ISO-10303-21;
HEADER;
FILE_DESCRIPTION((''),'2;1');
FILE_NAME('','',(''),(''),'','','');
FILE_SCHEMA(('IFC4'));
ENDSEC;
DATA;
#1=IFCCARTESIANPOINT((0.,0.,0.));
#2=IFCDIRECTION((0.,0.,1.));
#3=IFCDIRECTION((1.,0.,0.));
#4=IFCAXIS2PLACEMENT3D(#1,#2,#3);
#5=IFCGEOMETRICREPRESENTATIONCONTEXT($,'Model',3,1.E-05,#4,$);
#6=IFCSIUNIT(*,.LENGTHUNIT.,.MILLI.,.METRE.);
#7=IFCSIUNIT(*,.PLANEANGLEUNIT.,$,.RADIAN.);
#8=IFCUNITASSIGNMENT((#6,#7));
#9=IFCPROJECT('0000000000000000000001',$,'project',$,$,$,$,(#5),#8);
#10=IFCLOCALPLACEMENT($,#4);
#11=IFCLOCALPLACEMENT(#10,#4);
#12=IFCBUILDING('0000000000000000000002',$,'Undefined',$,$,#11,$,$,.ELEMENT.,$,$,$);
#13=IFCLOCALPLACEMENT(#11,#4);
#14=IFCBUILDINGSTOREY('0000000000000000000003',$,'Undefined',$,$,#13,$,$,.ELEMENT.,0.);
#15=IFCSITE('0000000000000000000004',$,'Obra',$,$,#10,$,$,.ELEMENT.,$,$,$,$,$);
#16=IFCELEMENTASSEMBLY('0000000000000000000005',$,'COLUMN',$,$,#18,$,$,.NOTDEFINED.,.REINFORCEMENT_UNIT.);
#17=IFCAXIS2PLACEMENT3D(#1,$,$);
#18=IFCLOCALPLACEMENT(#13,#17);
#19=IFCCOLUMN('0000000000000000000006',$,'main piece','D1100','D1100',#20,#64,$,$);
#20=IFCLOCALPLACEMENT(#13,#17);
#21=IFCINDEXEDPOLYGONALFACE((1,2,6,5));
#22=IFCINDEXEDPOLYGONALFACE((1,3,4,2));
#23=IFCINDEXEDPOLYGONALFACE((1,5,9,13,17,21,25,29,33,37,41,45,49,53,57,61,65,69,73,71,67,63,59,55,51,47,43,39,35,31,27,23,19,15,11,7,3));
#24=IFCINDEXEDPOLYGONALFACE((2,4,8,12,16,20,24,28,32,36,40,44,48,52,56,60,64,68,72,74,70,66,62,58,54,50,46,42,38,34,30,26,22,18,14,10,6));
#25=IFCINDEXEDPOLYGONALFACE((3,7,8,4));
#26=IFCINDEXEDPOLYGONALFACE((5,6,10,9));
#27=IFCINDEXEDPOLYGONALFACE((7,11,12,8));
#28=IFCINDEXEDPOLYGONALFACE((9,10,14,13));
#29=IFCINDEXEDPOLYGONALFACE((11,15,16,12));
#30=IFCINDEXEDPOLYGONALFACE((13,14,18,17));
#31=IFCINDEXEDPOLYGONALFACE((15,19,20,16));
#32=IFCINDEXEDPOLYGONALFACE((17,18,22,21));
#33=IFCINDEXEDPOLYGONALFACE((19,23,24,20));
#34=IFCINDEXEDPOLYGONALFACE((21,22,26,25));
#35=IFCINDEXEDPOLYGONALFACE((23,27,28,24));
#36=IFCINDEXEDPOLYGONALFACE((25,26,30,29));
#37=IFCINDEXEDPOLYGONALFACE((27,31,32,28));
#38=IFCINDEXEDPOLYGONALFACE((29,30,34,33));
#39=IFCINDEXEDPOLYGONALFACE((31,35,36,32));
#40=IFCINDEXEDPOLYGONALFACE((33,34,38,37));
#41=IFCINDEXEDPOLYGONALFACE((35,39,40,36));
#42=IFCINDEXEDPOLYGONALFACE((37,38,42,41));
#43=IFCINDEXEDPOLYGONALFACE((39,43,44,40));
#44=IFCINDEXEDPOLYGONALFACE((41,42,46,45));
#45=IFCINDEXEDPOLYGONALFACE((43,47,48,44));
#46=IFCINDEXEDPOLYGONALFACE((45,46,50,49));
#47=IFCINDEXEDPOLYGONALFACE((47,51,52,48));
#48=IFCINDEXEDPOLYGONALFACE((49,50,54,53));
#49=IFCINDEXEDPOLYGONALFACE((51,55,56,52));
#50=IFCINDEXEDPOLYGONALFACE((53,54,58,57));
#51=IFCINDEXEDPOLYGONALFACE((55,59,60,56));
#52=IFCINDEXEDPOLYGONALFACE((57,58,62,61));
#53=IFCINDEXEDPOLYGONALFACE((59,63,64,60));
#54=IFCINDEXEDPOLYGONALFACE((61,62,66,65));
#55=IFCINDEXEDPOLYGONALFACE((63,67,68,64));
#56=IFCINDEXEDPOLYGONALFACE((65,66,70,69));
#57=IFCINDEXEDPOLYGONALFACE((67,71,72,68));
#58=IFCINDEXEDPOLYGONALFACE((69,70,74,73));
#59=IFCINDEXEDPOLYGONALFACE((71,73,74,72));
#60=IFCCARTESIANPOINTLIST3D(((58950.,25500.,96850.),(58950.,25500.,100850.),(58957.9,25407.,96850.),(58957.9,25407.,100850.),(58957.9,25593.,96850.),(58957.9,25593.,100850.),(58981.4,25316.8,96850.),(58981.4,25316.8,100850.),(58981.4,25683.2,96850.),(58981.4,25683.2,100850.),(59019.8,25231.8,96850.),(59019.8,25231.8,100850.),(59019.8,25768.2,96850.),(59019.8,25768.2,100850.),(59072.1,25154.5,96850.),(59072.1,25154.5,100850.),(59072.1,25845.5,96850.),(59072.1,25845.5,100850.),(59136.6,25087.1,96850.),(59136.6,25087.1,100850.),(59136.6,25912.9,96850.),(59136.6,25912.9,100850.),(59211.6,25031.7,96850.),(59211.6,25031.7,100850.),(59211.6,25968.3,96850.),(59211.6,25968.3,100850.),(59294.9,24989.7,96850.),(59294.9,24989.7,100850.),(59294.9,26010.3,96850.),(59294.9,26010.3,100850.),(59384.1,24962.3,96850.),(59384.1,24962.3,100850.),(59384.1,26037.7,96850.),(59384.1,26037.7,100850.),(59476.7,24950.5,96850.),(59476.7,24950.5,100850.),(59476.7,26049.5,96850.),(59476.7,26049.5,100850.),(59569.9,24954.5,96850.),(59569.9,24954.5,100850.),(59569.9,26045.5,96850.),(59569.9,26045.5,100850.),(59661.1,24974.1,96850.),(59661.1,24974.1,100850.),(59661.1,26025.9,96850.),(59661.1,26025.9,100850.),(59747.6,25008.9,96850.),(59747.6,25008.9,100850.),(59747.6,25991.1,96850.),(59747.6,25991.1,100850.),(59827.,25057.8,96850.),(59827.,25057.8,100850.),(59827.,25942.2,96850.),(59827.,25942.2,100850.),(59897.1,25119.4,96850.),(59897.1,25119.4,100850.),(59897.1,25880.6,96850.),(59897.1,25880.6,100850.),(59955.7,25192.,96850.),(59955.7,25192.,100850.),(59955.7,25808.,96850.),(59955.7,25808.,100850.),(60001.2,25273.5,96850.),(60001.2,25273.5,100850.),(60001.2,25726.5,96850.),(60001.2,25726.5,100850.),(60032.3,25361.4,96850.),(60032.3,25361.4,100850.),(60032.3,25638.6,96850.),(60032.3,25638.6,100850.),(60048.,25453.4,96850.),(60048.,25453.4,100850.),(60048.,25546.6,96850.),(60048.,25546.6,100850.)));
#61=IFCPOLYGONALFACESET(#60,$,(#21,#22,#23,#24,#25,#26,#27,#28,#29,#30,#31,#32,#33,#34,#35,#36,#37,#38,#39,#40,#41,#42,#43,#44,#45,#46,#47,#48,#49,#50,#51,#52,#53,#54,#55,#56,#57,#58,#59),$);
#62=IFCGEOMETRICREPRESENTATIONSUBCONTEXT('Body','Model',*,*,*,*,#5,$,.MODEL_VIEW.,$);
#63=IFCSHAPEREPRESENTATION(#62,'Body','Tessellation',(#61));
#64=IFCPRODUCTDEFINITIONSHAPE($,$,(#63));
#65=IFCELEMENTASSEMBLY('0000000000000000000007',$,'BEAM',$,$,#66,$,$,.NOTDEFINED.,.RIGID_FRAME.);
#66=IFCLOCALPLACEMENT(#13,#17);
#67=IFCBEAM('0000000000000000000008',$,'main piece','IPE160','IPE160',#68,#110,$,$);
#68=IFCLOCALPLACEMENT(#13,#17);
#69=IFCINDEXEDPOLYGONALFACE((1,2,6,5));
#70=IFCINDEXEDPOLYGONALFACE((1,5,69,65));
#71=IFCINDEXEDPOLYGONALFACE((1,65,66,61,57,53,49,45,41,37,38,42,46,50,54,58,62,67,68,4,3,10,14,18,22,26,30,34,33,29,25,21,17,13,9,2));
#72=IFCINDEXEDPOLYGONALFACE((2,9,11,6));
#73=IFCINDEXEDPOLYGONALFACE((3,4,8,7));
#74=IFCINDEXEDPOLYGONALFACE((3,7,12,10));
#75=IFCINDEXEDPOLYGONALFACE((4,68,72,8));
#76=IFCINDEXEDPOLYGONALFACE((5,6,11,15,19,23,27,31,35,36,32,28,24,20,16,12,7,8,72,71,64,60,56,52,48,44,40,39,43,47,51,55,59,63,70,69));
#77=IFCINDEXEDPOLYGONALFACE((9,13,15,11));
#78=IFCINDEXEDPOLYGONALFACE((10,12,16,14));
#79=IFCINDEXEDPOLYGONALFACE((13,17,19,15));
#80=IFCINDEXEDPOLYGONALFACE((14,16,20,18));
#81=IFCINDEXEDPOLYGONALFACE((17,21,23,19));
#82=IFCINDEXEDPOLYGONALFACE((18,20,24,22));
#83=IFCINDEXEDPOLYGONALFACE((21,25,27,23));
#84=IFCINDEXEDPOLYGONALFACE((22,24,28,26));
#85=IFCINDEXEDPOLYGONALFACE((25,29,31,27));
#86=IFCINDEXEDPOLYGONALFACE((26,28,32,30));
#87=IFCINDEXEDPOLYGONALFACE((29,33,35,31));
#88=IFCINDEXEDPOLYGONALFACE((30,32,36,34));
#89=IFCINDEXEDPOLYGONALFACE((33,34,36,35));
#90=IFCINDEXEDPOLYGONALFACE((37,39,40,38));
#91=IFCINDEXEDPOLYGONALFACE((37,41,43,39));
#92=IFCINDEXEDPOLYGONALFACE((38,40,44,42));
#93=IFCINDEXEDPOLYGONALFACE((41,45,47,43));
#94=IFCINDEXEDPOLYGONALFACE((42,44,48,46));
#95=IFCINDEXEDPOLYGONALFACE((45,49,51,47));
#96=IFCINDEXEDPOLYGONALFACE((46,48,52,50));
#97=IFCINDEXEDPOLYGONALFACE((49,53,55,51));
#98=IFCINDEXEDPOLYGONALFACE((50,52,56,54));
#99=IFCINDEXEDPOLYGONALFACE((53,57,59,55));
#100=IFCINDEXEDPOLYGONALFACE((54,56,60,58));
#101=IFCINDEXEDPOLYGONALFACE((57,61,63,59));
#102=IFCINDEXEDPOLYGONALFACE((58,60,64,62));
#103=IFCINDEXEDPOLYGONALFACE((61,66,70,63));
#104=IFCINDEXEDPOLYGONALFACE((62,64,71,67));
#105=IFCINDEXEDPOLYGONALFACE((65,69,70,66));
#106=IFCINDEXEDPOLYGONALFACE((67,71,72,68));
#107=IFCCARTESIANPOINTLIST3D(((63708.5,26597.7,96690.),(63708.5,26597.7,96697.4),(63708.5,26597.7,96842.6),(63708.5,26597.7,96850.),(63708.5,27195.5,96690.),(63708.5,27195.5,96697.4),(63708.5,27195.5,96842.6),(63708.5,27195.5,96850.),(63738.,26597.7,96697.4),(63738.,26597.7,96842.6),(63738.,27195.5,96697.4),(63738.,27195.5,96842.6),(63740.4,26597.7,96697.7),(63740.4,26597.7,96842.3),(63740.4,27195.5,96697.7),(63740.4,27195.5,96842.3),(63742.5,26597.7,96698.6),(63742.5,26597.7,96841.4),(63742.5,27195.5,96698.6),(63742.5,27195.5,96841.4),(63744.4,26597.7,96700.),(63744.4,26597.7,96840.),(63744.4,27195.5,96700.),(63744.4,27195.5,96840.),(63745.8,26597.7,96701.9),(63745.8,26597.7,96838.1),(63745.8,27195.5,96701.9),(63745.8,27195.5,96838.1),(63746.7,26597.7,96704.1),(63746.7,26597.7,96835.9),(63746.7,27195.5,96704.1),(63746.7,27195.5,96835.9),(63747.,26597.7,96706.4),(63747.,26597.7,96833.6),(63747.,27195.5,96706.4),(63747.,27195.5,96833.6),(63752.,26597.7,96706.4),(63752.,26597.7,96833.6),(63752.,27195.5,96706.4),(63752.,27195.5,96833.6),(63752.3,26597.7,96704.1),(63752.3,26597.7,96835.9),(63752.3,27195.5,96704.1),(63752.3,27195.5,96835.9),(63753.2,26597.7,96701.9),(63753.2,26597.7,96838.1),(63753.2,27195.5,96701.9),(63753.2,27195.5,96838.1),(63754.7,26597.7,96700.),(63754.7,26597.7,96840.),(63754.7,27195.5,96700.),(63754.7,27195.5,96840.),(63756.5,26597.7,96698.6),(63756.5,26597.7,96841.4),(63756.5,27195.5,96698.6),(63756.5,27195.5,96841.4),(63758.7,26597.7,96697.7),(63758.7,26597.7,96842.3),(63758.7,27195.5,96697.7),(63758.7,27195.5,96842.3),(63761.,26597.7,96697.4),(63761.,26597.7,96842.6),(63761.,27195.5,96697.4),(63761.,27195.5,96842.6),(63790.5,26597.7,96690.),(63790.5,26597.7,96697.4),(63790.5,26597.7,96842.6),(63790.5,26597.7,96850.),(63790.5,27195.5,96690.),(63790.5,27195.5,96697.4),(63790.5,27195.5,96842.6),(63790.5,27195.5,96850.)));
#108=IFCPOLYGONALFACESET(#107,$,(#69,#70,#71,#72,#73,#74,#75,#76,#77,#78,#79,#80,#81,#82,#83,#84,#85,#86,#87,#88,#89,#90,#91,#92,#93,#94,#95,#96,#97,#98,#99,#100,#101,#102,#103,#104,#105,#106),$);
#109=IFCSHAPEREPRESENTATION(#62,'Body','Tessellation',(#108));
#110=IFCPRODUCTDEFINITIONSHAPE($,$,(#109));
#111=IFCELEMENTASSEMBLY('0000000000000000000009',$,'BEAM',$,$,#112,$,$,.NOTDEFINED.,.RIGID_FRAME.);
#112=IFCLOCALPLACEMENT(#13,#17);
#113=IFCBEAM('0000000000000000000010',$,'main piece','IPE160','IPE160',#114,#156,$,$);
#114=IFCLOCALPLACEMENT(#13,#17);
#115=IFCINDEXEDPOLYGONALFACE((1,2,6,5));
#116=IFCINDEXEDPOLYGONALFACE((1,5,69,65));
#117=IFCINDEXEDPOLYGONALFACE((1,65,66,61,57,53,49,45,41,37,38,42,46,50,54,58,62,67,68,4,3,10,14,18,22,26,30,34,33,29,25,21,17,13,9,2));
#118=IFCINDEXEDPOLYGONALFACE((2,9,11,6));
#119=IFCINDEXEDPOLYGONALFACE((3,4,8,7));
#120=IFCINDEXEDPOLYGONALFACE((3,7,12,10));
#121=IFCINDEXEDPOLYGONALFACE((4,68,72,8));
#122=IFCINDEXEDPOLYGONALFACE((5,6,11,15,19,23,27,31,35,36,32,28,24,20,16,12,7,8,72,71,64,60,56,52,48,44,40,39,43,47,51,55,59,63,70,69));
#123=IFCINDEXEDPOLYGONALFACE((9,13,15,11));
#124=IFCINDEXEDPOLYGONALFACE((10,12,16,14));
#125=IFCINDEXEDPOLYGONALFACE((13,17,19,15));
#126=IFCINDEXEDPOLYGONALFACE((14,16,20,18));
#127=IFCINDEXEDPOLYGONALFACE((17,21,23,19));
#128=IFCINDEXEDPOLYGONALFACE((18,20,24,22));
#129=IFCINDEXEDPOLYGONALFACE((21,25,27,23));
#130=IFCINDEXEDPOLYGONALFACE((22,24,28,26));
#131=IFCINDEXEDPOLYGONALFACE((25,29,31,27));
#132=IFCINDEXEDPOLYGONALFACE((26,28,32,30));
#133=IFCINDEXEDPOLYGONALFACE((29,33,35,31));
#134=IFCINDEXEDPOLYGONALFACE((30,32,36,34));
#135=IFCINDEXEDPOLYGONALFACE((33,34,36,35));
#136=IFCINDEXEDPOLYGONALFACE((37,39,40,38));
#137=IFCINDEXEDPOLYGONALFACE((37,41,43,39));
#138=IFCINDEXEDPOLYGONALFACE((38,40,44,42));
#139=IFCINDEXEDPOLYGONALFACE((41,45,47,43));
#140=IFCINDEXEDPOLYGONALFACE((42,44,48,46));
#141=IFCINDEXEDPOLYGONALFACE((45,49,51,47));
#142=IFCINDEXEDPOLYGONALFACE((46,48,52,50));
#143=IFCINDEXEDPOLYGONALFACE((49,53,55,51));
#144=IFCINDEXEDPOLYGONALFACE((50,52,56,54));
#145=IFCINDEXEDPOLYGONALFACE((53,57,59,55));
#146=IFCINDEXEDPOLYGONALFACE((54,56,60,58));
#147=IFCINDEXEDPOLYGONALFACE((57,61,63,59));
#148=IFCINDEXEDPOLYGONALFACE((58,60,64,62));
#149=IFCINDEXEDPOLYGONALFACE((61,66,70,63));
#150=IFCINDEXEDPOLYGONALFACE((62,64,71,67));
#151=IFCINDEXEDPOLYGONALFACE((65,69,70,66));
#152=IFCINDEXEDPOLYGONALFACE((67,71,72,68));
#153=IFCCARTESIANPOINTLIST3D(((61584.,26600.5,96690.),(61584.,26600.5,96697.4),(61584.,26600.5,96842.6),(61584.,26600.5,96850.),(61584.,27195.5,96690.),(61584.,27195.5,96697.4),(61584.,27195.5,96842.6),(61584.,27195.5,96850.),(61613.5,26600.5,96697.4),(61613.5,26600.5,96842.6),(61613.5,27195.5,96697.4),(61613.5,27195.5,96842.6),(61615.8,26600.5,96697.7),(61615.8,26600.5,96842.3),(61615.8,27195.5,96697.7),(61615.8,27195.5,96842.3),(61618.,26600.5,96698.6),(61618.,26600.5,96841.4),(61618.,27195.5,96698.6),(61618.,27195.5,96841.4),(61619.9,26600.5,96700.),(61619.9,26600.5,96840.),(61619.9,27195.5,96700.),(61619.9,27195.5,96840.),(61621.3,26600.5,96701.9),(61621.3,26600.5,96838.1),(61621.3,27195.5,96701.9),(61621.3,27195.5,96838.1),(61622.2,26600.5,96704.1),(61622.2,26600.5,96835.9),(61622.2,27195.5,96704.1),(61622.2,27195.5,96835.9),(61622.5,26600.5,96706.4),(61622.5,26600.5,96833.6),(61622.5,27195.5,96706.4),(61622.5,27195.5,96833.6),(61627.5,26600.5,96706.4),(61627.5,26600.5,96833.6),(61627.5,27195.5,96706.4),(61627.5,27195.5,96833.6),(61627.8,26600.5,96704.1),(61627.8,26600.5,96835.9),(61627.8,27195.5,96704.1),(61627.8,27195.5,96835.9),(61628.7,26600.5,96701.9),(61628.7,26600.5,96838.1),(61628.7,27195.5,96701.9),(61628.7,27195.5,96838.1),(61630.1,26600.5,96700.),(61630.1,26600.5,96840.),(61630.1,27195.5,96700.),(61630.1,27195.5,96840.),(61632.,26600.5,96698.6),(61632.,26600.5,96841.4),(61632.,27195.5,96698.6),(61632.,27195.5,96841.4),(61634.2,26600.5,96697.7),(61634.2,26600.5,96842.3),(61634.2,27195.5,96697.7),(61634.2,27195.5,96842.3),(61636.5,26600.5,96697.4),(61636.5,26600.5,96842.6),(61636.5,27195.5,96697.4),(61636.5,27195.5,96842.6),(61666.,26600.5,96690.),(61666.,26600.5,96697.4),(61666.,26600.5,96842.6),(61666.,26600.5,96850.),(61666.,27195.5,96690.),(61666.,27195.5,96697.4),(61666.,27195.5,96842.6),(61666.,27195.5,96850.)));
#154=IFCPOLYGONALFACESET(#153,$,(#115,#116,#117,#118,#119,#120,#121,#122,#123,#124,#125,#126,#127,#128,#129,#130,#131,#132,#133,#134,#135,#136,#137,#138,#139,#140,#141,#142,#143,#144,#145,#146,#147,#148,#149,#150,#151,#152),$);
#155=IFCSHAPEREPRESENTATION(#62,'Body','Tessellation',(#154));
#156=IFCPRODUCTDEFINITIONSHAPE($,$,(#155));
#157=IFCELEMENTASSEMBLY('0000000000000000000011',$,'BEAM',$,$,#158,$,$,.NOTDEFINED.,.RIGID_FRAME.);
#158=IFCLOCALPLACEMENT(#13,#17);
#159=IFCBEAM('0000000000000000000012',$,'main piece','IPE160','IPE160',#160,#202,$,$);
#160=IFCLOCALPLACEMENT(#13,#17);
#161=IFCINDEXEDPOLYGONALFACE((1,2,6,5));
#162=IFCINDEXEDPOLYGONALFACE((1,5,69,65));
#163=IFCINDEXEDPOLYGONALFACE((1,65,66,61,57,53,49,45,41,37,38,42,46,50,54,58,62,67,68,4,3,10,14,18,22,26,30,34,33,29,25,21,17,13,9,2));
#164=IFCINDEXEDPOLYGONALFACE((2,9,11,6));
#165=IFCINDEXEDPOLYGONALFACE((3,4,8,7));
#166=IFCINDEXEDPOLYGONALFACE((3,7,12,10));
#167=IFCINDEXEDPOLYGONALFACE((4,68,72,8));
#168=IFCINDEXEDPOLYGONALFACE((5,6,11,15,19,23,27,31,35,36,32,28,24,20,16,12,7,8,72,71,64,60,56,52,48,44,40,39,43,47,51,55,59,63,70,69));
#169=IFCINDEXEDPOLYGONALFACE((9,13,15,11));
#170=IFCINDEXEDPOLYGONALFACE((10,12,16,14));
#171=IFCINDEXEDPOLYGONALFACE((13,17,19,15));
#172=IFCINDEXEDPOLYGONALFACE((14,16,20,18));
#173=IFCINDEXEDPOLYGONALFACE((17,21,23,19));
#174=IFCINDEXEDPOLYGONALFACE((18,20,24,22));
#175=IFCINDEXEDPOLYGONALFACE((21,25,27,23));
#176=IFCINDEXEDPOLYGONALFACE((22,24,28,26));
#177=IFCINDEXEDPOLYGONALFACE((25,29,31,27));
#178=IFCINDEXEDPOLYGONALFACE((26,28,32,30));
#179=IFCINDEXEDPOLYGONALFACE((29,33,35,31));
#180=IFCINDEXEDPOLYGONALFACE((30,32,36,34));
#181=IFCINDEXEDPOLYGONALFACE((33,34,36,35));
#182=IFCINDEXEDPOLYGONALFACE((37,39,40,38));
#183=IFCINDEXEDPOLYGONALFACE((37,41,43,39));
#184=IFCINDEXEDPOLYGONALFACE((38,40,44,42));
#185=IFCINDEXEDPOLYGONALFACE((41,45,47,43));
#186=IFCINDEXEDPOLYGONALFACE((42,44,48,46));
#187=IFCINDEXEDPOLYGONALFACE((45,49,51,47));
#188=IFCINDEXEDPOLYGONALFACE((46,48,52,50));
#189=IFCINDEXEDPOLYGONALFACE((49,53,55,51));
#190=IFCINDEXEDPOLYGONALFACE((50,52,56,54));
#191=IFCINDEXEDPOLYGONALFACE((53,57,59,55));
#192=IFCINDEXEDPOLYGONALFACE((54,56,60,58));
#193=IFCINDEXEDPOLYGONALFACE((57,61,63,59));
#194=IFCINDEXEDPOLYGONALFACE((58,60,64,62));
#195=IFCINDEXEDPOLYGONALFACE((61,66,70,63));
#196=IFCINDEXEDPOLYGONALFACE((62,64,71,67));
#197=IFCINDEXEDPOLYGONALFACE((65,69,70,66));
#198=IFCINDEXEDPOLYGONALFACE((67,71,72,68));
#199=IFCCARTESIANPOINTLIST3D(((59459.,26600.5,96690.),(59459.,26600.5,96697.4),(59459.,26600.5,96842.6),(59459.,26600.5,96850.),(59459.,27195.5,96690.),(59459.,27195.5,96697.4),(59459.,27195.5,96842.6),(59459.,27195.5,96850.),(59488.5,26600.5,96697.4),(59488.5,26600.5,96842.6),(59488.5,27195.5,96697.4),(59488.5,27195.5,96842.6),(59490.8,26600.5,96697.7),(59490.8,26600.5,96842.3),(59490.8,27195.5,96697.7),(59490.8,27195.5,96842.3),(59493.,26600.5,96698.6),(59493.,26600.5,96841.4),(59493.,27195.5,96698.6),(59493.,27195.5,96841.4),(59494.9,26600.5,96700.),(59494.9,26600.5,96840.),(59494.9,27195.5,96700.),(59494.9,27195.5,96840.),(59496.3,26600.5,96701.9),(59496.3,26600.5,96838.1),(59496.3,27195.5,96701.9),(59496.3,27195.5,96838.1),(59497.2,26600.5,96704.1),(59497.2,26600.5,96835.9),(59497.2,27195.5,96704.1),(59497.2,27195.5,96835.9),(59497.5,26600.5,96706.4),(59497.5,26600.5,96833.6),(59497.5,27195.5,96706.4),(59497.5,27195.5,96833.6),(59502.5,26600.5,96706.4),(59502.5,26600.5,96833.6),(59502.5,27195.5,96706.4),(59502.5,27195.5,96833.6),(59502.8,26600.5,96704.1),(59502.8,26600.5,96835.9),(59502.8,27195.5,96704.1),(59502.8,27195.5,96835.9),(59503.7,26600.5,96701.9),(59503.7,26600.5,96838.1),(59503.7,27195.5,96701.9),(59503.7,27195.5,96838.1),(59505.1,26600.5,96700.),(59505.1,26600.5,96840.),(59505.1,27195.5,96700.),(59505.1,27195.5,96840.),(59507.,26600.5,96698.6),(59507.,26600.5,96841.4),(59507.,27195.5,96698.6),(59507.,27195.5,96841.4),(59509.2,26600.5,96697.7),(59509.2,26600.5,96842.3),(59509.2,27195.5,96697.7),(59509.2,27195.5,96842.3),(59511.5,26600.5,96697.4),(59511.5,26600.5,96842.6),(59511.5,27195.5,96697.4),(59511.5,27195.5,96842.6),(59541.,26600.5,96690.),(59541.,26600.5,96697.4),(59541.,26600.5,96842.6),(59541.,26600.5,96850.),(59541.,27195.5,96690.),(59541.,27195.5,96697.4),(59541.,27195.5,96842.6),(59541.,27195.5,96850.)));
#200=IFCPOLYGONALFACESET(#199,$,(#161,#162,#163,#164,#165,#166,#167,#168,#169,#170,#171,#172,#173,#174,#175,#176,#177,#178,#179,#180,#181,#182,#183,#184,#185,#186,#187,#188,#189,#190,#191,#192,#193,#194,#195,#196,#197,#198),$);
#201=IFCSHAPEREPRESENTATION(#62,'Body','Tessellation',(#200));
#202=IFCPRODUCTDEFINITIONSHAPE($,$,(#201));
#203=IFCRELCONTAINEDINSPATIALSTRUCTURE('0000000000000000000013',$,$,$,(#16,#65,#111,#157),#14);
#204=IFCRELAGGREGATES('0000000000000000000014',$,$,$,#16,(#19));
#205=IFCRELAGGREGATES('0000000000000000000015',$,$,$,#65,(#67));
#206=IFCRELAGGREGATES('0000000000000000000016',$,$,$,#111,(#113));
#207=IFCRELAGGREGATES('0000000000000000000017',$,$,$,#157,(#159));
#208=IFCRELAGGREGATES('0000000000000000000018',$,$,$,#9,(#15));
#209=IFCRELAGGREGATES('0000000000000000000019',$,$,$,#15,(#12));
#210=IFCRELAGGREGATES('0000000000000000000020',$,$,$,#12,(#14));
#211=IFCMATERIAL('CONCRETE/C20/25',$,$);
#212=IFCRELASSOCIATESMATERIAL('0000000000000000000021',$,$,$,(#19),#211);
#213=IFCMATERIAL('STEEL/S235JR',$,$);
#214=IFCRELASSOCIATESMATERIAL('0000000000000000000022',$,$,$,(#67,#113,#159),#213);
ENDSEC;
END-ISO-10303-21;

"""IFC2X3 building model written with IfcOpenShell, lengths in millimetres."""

from ifc_helpers import new_model, si_unit, frame, origin_with_axes, origin_2d_with_axis, place, context, subcontext, project, spatial, circle, i_section, extrude, material, element, aggregate, save


model = new_model("IFC2X3")

# Units and contexts
model_context = context("Model", 3, precision=1e-05, world=origin_with_axes())
body_context = subcontext(model_context, "Body", "Model", "MODEL_VIEW")
ifc_project = project(units=[si_unit("LENGTHUNIT", "METRE", prefix="MILLI"), si_unit("PLANEANGLEUNIT", "RADIAN")], contexts=[model_context])

# Site, building, storey
site_placement = place(None, origin_with_axes())
site = spatial("IfcSite", under=ifc_project, at=site_placement, Name="Obra", CompositionType="ELEMENT")
building_placement = place(site_placement, origin_with_axes())
building = spatial("IfcBuilding", under=site, at=building_placement, Name="Undefined", CompositionType="ELEMENT")
storey_placement = place(building_placement, origin_with_axes())
storey = spatial("IfcBuildingStorey", under=building, at=storey_placement, Name="Undefined", CompositionType="ELEMENT", Elevation=0.0)

# Element assembly, column
assembly_1_placement = place(storey_placement, origin_with_axes())
assembly_1 = element("IfcElementAssembly", 1, at=assembly_1_placement, inside=storey, Name="COLUMN", AssemblyPlace="NOTDEFINED", PredefinedType="REINFORCEMENT_UNIT")
ifc_material_1 = material(Name="CONCRETE/C20/25")
column_placement = place(assembly_1_placement, frame((59500.0, 25500.0, 96850.0), z_axis=(0.0, 0.0, 1.0), x_axis=(0.0, 1.0, 0.0)))
column = element("IfcColumn", 2, at=column_placement, material=ifc_material_1, Name="main piece", Description="D1100", ObjectType="D1100", context=body_context, shape_type="SweptSolid", body=[
    extrude(circle(Radius=550.0, at=origin_2d_with_axis()), frame((0.0, 0.0, 4000.0), z_axis=(0.0, 0.0, -1.0), x_axis=(0.0, 1.0, 0.0)), (0.0, 0.0, 1.0), 4000.0),
])
aggregate(assembly_1, [column])

# Element assemblies, beams
assembly_2_placement = place(storey_placement, origin_with_axes())
assembly_2 = element("IfcElementAssembly", 3, at=assembly_2_placement, inside=storey, Name="BEAM", AssemblyPlace="NOTDEFINED", PredefinedType="RIGID_FRAME")
ifc_material_2 = material(Name="STEEL/S235JR")
beam_1_placement = place(assembly_2_placement, frame((63749.5, 26597.7, 96770.0), z_axis=(0.0, 0.0, 1.0), x_axis=(0.0, 1.0, 0.0)))
beam_1 = element("IfcBeam", 4, at=beam_1_placement, material=ifc_material_2, Name="main piece", Description="IPE160", ObjectType="IPE160", context=body_context, shape_type="SweptSolid", body=[
    extrude(i_section(OverallWidth=82.0, OverallDepth=160.0, WebThickness=5.0, FlangeThickness=7.4, FilletRadius=9.0, at=origin_2d_with_axis()), frame((597.8, 0.0, 0.0), z_axis=(-1.0, 0.0, 0.0), x_axis=(0.0, -1.0, 0.0)), (0.0, 0.0, 1.0), 597.8),
])
aggregate(assembly_2, [beam_1])
assembly_3_placement = place(storey_placement, origin_with_axes())
assembly_3 = element("IfcElementAssembly", 5, at=assembly_3_placement, inside=storey, Name="BEAM", AssemblyPlace="NOTDEFINED", PredefinedType="RIGID_FRAME")
beam_2_placement = place(assembly_3_placement, frame((61625.0, 27195.5, 96770.0), z_axis=(0.0, 0.0, 1.0), x_axis=(0.0, -1.0, 0.0)))
beam_2 = element("IfcBeam", 6, at=beam_2_placement, material=ifc_material_2, Name="main piece", Description="IPE160", ObjectType="IPE160", context=body_context, shape_type="SweptSolid", body=[
    extrude(i_section(OverallWidth=82.0, OverallDepth=160.0, WebThickness=5.0, FlangeThickness=7.4, FilletRadius=9.0, at=origin_2d_with_axis()), frame((595.0, 0.0, 0.0), z_axis=(-1.0, 0.0, 0.0), x_axis=(0.0, -1.0, 0.0)), (0.0, 0.0, 1.0), 595.0),
])
aggregate(assembly_3, [beam_2])
assembly_4_placement = place(storey_placement, origin_with_axes())
assembly_4 = element("IfcElementAssembly", 7, at=assembly_4_placement, inside=storey, Name="BEAM", AssemblyPlace="NOTDEFINED", PredefinedType="RIGID_FRAME")
beam_3_placement = place(assembly_4_placement, frame((59500.0, 26600.5, 96770.0), z_axis=(0.0, 0.0, 1.0), x_axis=(0.0, 1.0, 0.0)))
beam_3 = element("IfcBeam", 8, at=beam_3_placement, material=ifc_material_2, Name="main piece", Description="IPE160", ObjectType="IPE160", context=body_context, shape_type="SweptSolid", body=[
    extrude(i_section(OverallWidth=82.0, OverallDepth=160.0, WebThickness=5.0, FlangeThickness=7.4, FilletRadius=9.0, at=origin_2d_with_axis()), frame((595.0, 0.0, 0.0), z_axis=(-1.0, 0.0, 0.0), x_axis=(0.0, -1.0, 0.0)), (0.0, 0.0, 1.0), 595.0),
])
aggregate(assembly_4, [beam_3])

save(model, "model.ifc")
